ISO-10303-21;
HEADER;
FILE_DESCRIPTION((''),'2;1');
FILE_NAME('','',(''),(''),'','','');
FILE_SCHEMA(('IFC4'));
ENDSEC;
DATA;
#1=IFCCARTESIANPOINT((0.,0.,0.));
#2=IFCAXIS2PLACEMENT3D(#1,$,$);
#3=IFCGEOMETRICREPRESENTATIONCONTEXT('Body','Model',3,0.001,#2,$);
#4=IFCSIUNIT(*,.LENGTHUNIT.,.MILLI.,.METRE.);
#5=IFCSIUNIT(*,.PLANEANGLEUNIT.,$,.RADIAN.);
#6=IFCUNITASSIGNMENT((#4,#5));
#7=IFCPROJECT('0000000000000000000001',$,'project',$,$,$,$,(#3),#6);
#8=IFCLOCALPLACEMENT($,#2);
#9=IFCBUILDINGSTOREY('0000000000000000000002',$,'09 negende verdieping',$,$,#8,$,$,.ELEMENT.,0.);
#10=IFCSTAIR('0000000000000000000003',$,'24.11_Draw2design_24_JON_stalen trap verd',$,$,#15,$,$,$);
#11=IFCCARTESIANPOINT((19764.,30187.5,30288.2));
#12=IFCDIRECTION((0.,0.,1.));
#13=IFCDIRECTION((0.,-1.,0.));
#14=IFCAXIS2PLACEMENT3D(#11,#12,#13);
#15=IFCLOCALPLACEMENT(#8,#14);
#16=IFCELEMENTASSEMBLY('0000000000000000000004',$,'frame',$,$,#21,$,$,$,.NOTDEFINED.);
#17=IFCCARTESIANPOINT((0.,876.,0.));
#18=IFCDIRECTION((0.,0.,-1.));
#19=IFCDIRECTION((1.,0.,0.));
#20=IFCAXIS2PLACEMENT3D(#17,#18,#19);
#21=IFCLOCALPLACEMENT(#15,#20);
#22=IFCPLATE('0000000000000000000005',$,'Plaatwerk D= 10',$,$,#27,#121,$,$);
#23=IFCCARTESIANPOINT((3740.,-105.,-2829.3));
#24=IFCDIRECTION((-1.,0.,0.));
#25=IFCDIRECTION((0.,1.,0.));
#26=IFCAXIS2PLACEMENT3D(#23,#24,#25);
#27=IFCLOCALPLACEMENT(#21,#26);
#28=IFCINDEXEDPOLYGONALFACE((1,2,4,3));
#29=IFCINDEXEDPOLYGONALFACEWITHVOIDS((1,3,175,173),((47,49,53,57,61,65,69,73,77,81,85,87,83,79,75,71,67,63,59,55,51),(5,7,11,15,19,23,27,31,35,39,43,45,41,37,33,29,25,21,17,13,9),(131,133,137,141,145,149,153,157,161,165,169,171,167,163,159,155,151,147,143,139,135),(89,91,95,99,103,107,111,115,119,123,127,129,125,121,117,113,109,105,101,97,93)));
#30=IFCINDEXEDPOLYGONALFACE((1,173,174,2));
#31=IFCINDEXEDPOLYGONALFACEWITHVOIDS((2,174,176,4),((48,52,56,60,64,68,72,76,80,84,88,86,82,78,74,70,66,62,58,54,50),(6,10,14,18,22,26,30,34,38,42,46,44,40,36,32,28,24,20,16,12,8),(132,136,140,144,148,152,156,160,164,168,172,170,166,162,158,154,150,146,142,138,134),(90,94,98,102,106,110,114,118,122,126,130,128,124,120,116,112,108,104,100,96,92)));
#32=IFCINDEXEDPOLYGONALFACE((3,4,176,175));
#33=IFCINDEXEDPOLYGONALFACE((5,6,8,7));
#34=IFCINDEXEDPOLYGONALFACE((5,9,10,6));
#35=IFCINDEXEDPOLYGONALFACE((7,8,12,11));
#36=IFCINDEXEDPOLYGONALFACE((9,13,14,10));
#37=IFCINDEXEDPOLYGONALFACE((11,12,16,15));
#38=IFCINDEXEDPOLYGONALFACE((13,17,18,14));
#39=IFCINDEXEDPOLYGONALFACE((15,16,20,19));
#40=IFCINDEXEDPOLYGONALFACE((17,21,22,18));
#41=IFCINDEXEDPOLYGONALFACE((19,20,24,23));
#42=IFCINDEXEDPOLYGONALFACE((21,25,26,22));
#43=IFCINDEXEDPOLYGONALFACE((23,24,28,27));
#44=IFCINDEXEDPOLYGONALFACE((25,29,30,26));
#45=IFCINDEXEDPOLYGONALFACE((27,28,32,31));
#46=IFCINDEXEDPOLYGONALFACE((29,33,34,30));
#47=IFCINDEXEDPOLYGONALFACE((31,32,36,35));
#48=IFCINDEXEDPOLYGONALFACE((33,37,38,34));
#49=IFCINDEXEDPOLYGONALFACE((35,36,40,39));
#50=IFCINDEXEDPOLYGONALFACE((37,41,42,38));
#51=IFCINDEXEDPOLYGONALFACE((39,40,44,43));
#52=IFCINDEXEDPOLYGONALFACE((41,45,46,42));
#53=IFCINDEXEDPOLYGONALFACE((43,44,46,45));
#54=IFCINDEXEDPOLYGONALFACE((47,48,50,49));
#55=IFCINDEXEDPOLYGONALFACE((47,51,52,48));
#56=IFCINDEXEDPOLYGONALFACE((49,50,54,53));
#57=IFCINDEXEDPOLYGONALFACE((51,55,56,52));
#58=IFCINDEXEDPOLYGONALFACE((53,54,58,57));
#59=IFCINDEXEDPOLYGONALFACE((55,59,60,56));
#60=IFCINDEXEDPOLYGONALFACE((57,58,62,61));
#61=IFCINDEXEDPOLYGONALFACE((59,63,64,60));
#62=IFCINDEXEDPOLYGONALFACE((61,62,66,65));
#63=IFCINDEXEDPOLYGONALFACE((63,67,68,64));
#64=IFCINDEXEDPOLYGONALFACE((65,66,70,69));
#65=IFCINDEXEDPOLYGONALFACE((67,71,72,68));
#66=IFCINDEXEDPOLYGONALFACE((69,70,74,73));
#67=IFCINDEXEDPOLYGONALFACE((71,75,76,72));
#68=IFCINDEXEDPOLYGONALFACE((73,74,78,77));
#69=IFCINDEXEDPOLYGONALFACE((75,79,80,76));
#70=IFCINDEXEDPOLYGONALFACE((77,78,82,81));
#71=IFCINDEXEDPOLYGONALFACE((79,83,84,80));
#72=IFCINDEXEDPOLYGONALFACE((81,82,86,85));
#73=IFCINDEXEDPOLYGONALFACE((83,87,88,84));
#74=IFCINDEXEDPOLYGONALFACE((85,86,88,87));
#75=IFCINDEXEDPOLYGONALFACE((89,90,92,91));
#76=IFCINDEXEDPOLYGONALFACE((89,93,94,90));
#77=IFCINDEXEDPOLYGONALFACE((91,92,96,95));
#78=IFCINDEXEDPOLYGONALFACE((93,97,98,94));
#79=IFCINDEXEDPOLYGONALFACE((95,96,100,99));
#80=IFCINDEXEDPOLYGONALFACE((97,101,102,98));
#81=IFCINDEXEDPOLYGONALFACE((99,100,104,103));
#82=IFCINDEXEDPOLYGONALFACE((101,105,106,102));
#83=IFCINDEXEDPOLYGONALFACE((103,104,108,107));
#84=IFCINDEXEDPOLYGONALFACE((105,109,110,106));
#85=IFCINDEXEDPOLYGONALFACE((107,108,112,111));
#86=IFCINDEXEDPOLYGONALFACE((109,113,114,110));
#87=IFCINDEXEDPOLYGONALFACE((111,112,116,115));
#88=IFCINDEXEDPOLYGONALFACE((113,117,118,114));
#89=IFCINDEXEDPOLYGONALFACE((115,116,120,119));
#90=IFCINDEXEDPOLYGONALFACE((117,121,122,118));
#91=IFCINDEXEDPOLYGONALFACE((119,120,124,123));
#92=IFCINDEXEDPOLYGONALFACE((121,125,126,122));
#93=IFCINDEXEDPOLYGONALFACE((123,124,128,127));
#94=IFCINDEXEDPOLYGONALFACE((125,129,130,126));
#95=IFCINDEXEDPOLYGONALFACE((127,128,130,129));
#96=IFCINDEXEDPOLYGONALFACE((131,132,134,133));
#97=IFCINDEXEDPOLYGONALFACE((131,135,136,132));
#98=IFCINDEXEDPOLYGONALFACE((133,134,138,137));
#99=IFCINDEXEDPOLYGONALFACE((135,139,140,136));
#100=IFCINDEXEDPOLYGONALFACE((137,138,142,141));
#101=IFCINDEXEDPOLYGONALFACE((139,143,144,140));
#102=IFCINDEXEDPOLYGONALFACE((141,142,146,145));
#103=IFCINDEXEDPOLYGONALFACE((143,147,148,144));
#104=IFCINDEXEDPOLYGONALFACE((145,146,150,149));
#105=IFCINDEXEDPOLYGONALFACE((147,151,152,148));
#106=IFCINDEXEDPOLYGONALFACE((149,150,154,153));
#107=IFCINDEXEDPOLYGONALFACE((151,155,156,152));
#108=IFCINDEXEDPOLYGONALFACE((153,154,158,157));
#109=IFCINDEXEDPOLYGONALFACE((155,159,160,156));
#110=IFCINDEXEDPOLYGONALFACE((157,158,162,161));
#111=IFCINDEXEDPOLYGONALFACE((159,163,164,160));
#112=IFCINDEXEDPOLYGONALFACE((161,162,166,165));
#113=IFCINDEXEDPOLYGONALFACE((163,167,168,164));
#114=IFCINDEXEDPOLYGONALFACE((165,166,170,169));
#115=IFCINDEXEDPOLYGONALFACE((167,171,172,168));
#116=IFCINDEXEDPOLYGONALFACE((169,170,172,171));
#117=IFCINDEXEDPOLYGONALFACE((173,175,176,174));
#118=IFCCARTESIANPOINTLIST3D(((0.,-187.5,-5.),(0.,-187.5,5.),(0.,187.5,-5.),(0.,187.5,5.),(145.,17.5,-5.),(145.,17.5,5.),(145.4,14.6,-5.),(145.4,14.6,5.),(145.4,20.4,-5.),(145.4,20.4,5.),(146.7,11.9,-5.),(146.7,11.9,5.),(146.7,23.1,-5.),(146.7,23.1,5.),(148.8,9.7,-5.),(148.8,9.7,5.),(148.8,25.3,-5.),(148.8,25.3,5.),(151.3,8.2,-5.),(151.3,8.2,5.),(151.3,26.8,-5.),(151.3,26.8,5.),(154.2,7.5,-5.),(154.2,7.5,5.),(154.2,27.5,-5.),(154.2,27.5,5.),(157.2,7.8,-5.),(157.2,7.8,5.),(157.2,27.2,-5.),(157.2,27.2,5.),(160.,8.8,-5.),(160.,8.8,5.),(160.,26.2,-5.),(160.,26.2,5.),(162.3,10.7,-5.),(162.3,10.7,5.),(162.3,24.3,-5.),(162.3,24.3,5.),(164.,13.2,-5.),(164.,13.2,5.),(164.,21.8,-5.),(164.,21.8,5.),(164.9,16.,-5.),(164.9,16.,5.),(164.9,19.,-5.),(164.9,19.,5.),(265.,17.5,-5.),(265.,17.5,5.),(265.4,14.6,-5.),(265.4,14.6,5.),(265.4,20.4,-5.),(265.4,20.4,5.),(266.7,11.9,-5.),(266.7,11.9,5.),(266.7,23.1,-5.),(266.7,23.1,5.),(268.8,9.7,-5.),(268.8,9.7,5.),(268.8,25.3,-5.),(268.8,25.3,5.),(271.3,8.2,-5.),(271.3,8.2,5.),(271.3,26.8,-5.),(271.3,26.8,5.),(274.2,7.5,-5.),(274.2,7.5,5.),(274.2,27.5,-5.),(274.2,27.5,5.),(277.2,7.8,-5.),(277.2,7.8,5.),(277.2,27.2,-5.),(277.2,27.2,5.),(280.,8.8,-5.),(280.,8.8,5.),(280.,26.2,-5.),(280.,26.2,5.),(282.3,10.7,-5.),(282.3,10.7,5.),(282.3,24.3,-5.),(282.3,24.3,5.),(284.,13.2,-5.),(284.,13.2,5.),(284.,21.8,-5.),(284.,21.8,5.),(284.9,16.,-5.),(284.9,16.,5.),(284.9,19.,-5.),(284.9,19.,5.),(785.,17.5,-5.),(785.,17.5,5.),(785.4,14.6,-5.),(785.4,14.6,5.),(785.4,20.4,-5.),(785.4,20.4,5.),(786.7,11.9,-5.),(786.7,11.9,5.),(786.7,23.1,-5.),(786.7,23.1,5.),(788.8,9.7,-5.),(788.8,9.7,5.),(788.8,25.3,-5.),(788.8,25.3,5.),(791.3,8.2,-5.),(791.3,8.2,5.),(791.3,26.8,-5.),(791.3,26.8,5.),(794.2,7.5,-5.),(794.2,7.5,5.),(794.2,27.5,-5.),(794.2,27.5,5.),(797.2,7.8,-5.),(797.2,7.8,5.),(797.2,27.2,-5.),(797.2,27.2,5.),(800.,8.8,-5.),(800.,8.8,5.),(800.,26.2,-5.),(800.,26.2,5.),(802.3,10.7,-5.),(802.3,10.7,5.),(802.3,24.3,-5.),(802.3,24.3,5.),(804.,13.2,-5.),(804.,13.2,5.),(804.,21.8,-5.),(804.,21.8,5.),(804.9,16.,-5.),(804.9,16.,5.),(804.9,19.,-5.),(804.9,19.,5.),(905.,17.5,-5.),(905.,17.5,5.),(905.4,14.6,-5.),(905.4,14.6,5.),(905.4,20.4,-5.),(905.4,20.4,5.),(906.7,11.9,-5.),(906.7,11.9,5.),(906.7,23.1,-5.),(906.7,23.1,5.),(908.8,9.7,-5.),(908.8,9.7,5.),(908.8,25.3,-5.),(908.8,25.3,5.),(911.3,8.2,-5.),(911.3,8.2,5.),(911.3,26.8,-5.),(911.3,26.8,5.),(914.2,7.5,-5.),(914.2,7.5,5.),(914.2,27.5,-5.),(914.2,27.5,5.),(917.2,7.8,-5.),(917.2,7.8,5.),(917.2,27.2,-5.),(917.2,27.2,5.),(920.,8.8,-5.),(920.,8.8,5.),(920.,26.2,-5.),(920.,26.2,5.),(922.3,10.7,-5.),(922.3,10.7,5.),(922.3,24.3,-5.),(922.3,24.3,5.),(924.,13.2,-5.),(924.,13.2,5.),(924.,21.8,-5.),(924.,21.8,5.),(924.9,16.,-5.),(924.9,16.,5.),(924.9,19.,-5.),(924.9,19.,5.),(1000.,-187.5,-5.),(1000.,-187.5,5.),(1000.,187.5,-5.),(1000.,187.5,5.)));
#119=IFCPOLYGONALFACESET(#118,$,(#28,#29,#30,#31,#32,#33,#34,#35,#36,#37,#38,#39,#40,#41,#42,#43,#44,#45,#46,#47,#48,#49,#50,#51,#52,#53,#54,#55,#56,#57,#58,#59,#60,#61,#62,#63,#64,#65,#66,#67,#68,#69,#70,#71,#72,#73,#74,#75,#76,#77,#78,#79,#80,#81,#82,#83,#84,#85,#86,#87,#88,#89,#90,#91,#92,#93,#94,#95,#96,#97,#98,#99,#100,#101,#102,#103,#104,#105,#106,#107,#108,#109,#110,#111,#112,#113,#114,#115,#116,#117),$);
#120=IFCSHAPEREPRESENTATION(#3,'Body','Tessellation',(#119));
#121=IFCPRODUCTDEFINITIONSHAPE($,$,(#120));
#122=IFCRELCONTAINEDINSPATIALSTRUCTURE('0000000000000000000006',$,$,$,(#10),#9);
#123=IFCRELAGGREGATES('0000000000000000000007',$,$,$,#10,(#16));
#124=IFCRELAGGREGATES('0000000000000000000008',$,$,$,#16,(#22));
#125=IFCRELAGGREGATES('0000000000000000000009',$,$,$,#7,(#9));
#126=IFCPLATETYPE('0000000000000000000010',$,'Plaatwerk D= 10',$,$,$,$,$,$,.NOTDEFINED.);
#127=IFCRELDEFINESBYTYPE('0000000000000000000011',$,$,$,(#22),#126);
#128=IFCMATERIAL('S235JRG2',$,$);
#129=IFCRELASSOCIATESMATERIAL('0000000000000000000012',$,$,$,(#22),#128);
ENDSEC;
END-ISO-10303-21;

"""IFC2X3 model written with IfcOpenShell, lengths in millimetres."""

from ifc_helpers import new_model, si_unit, frame, origin, origin_2d, place, context, project, spatial, rectangle, circle, extrude, source, transform, mapped, material, type_object, element, aggregate, save


model = new_model("IFC2X3")

# Units and contexts
model_context = context("Model", 3, precision=0.001, world=origin(), identifier="Body")
ifc_project = project(units=[si_unit("LENGTHUNIT", "METRE", prefix="MILLI"), si_unit("PLANEANGLEUNIT", "RADIAN")], contexts=[model_context])

# Storey
storey_placement = place(None, origin())
storey = spatial("IfcBuildingStorey", under=ifc_project, at=storey_placement, Name="09 negende verdieping", CompositionType="ELEMENT", Elevation=0.0)

# Stair
stair_placement = place(storey_placement, frame((19764.0, 30187.5, 30288.2), z_axis=(0.0, 0.0, 1.0), x_axis=(0.0, -1.0, 0.0)))
stair = element("IfcStair", 1, at=stair_placement, inside=storey, Name="24.11_Draw2design_24_JON_stalen trap verd")
ifc_material_1 = material(Name="S235JRG2")

# Element assembly
assembly_placement = place(stair_placement, frame((0.0, 876.0, 0.0), z_axis=(0.0, 0.0, -1.0), x_axis=(1.0, 0.0, 0.0)))
assembly = element("IfcElementAssembly", 2, at=assembly_placement, Name="frame", PredefinedType="NOTDEFINED")
aggregate(stair, [assembly])

# Plate, openings
plate_type = type_object("IfcPlateType", Name="Plaatwerk D= 10")
shared_shape_1 = source(origin(), model_context, "Body", "SweptSolid", [
    extrude(rectangle(XDim=1000.0, YDim=375.0, at=origin_2d()), frame((500.0, 0.0, -5.0)), (0.0, 0.0, 1.0), 10.0),
])
plate_placement = place(assembly_placement, frame((3740.0, -105.0, -2829.3), z_axis=(-1.0, 0.0, 0.0), x_axis=(0.0, 1.0, 0.0)))
plate = element("IfcPlate", 3, at=plate_placement, type_object=plate_type, material=ifc_material_1, Name="Plaatwerk D= 10", context=model_context, shape_type="MappedRepresentation", body=[
    mapped(shared_shape_1, transform((0.0, 0.0, 0.0), scale=1.0)),
])
opening_1_placement = place(plate_placement, frame((795.0, 17.5, -5.0), z_axis=(0.0, 0.0, 1.0), x_axis=(-1.0, 0.0, 0.0)))
element("IfcOpeningElement", 4, at=opening_1_placement, cuts=plate, ObjectType="Opening", context=model_context, shape_type="SweptSolid", body=[
    extrude(circle(Radius=10.0, at=origin_2d()), origin(), (0.0, 0.0, 1.0), 10.0),
])
opening_2_placement = place(plate_placement, frame((915.0, 17.5, -5.0), z_axis=(0.0, 0.0, 1.0), x_axis=(-1.0, 0.0, 0.0)))
element("IfcOpeningElement", 5, at=opening_2_placement, cuts=plate, ObjectType="Opening", context=model_context, shape_type="SweptSolid", body=[
    extrude(circle(Radius=10.0, at=origin_2d()), origin(), (0.0, 0.0, 1.0), 10.0),
])
opening_3_placement = place(plate_placement, frame((155.0, 17.5, -5.0), z_axis=(0.0, 0.0, 1.0), x_axis=(-1.0, 0.0, 0.0)))
element("IfcOpeningElement", 6, at=opening_3_placement, cuts=plate, ObjectType="Opening", context=model_context, shape_type="SweptSolid", body=[
    extrude(circle(Radius=10.0, at=origin_2d()), origin(), (0.0, 0.0, 1.0), 10.0),
])
opening_4_placement = place(plate_placement, frame((275.0, 17.5, -5.0), z_axis=(0.0, 0.0, 1.0), x_axis=(-1.0, 0.0, 0.0)))
element("IfcOpeningElement", 7, at=opening_4_placement, cuts=plate, ObjectType="Opening", context=model_context, shape_type="SweptSolid", body=[
    extrude(circle(Radius=10.0, at=origin_2d()), origin(), (0.0, 0.0, 1.0), 10.0),
])
aggregate(assembly, [plate])

save(model, "model.ifc")
